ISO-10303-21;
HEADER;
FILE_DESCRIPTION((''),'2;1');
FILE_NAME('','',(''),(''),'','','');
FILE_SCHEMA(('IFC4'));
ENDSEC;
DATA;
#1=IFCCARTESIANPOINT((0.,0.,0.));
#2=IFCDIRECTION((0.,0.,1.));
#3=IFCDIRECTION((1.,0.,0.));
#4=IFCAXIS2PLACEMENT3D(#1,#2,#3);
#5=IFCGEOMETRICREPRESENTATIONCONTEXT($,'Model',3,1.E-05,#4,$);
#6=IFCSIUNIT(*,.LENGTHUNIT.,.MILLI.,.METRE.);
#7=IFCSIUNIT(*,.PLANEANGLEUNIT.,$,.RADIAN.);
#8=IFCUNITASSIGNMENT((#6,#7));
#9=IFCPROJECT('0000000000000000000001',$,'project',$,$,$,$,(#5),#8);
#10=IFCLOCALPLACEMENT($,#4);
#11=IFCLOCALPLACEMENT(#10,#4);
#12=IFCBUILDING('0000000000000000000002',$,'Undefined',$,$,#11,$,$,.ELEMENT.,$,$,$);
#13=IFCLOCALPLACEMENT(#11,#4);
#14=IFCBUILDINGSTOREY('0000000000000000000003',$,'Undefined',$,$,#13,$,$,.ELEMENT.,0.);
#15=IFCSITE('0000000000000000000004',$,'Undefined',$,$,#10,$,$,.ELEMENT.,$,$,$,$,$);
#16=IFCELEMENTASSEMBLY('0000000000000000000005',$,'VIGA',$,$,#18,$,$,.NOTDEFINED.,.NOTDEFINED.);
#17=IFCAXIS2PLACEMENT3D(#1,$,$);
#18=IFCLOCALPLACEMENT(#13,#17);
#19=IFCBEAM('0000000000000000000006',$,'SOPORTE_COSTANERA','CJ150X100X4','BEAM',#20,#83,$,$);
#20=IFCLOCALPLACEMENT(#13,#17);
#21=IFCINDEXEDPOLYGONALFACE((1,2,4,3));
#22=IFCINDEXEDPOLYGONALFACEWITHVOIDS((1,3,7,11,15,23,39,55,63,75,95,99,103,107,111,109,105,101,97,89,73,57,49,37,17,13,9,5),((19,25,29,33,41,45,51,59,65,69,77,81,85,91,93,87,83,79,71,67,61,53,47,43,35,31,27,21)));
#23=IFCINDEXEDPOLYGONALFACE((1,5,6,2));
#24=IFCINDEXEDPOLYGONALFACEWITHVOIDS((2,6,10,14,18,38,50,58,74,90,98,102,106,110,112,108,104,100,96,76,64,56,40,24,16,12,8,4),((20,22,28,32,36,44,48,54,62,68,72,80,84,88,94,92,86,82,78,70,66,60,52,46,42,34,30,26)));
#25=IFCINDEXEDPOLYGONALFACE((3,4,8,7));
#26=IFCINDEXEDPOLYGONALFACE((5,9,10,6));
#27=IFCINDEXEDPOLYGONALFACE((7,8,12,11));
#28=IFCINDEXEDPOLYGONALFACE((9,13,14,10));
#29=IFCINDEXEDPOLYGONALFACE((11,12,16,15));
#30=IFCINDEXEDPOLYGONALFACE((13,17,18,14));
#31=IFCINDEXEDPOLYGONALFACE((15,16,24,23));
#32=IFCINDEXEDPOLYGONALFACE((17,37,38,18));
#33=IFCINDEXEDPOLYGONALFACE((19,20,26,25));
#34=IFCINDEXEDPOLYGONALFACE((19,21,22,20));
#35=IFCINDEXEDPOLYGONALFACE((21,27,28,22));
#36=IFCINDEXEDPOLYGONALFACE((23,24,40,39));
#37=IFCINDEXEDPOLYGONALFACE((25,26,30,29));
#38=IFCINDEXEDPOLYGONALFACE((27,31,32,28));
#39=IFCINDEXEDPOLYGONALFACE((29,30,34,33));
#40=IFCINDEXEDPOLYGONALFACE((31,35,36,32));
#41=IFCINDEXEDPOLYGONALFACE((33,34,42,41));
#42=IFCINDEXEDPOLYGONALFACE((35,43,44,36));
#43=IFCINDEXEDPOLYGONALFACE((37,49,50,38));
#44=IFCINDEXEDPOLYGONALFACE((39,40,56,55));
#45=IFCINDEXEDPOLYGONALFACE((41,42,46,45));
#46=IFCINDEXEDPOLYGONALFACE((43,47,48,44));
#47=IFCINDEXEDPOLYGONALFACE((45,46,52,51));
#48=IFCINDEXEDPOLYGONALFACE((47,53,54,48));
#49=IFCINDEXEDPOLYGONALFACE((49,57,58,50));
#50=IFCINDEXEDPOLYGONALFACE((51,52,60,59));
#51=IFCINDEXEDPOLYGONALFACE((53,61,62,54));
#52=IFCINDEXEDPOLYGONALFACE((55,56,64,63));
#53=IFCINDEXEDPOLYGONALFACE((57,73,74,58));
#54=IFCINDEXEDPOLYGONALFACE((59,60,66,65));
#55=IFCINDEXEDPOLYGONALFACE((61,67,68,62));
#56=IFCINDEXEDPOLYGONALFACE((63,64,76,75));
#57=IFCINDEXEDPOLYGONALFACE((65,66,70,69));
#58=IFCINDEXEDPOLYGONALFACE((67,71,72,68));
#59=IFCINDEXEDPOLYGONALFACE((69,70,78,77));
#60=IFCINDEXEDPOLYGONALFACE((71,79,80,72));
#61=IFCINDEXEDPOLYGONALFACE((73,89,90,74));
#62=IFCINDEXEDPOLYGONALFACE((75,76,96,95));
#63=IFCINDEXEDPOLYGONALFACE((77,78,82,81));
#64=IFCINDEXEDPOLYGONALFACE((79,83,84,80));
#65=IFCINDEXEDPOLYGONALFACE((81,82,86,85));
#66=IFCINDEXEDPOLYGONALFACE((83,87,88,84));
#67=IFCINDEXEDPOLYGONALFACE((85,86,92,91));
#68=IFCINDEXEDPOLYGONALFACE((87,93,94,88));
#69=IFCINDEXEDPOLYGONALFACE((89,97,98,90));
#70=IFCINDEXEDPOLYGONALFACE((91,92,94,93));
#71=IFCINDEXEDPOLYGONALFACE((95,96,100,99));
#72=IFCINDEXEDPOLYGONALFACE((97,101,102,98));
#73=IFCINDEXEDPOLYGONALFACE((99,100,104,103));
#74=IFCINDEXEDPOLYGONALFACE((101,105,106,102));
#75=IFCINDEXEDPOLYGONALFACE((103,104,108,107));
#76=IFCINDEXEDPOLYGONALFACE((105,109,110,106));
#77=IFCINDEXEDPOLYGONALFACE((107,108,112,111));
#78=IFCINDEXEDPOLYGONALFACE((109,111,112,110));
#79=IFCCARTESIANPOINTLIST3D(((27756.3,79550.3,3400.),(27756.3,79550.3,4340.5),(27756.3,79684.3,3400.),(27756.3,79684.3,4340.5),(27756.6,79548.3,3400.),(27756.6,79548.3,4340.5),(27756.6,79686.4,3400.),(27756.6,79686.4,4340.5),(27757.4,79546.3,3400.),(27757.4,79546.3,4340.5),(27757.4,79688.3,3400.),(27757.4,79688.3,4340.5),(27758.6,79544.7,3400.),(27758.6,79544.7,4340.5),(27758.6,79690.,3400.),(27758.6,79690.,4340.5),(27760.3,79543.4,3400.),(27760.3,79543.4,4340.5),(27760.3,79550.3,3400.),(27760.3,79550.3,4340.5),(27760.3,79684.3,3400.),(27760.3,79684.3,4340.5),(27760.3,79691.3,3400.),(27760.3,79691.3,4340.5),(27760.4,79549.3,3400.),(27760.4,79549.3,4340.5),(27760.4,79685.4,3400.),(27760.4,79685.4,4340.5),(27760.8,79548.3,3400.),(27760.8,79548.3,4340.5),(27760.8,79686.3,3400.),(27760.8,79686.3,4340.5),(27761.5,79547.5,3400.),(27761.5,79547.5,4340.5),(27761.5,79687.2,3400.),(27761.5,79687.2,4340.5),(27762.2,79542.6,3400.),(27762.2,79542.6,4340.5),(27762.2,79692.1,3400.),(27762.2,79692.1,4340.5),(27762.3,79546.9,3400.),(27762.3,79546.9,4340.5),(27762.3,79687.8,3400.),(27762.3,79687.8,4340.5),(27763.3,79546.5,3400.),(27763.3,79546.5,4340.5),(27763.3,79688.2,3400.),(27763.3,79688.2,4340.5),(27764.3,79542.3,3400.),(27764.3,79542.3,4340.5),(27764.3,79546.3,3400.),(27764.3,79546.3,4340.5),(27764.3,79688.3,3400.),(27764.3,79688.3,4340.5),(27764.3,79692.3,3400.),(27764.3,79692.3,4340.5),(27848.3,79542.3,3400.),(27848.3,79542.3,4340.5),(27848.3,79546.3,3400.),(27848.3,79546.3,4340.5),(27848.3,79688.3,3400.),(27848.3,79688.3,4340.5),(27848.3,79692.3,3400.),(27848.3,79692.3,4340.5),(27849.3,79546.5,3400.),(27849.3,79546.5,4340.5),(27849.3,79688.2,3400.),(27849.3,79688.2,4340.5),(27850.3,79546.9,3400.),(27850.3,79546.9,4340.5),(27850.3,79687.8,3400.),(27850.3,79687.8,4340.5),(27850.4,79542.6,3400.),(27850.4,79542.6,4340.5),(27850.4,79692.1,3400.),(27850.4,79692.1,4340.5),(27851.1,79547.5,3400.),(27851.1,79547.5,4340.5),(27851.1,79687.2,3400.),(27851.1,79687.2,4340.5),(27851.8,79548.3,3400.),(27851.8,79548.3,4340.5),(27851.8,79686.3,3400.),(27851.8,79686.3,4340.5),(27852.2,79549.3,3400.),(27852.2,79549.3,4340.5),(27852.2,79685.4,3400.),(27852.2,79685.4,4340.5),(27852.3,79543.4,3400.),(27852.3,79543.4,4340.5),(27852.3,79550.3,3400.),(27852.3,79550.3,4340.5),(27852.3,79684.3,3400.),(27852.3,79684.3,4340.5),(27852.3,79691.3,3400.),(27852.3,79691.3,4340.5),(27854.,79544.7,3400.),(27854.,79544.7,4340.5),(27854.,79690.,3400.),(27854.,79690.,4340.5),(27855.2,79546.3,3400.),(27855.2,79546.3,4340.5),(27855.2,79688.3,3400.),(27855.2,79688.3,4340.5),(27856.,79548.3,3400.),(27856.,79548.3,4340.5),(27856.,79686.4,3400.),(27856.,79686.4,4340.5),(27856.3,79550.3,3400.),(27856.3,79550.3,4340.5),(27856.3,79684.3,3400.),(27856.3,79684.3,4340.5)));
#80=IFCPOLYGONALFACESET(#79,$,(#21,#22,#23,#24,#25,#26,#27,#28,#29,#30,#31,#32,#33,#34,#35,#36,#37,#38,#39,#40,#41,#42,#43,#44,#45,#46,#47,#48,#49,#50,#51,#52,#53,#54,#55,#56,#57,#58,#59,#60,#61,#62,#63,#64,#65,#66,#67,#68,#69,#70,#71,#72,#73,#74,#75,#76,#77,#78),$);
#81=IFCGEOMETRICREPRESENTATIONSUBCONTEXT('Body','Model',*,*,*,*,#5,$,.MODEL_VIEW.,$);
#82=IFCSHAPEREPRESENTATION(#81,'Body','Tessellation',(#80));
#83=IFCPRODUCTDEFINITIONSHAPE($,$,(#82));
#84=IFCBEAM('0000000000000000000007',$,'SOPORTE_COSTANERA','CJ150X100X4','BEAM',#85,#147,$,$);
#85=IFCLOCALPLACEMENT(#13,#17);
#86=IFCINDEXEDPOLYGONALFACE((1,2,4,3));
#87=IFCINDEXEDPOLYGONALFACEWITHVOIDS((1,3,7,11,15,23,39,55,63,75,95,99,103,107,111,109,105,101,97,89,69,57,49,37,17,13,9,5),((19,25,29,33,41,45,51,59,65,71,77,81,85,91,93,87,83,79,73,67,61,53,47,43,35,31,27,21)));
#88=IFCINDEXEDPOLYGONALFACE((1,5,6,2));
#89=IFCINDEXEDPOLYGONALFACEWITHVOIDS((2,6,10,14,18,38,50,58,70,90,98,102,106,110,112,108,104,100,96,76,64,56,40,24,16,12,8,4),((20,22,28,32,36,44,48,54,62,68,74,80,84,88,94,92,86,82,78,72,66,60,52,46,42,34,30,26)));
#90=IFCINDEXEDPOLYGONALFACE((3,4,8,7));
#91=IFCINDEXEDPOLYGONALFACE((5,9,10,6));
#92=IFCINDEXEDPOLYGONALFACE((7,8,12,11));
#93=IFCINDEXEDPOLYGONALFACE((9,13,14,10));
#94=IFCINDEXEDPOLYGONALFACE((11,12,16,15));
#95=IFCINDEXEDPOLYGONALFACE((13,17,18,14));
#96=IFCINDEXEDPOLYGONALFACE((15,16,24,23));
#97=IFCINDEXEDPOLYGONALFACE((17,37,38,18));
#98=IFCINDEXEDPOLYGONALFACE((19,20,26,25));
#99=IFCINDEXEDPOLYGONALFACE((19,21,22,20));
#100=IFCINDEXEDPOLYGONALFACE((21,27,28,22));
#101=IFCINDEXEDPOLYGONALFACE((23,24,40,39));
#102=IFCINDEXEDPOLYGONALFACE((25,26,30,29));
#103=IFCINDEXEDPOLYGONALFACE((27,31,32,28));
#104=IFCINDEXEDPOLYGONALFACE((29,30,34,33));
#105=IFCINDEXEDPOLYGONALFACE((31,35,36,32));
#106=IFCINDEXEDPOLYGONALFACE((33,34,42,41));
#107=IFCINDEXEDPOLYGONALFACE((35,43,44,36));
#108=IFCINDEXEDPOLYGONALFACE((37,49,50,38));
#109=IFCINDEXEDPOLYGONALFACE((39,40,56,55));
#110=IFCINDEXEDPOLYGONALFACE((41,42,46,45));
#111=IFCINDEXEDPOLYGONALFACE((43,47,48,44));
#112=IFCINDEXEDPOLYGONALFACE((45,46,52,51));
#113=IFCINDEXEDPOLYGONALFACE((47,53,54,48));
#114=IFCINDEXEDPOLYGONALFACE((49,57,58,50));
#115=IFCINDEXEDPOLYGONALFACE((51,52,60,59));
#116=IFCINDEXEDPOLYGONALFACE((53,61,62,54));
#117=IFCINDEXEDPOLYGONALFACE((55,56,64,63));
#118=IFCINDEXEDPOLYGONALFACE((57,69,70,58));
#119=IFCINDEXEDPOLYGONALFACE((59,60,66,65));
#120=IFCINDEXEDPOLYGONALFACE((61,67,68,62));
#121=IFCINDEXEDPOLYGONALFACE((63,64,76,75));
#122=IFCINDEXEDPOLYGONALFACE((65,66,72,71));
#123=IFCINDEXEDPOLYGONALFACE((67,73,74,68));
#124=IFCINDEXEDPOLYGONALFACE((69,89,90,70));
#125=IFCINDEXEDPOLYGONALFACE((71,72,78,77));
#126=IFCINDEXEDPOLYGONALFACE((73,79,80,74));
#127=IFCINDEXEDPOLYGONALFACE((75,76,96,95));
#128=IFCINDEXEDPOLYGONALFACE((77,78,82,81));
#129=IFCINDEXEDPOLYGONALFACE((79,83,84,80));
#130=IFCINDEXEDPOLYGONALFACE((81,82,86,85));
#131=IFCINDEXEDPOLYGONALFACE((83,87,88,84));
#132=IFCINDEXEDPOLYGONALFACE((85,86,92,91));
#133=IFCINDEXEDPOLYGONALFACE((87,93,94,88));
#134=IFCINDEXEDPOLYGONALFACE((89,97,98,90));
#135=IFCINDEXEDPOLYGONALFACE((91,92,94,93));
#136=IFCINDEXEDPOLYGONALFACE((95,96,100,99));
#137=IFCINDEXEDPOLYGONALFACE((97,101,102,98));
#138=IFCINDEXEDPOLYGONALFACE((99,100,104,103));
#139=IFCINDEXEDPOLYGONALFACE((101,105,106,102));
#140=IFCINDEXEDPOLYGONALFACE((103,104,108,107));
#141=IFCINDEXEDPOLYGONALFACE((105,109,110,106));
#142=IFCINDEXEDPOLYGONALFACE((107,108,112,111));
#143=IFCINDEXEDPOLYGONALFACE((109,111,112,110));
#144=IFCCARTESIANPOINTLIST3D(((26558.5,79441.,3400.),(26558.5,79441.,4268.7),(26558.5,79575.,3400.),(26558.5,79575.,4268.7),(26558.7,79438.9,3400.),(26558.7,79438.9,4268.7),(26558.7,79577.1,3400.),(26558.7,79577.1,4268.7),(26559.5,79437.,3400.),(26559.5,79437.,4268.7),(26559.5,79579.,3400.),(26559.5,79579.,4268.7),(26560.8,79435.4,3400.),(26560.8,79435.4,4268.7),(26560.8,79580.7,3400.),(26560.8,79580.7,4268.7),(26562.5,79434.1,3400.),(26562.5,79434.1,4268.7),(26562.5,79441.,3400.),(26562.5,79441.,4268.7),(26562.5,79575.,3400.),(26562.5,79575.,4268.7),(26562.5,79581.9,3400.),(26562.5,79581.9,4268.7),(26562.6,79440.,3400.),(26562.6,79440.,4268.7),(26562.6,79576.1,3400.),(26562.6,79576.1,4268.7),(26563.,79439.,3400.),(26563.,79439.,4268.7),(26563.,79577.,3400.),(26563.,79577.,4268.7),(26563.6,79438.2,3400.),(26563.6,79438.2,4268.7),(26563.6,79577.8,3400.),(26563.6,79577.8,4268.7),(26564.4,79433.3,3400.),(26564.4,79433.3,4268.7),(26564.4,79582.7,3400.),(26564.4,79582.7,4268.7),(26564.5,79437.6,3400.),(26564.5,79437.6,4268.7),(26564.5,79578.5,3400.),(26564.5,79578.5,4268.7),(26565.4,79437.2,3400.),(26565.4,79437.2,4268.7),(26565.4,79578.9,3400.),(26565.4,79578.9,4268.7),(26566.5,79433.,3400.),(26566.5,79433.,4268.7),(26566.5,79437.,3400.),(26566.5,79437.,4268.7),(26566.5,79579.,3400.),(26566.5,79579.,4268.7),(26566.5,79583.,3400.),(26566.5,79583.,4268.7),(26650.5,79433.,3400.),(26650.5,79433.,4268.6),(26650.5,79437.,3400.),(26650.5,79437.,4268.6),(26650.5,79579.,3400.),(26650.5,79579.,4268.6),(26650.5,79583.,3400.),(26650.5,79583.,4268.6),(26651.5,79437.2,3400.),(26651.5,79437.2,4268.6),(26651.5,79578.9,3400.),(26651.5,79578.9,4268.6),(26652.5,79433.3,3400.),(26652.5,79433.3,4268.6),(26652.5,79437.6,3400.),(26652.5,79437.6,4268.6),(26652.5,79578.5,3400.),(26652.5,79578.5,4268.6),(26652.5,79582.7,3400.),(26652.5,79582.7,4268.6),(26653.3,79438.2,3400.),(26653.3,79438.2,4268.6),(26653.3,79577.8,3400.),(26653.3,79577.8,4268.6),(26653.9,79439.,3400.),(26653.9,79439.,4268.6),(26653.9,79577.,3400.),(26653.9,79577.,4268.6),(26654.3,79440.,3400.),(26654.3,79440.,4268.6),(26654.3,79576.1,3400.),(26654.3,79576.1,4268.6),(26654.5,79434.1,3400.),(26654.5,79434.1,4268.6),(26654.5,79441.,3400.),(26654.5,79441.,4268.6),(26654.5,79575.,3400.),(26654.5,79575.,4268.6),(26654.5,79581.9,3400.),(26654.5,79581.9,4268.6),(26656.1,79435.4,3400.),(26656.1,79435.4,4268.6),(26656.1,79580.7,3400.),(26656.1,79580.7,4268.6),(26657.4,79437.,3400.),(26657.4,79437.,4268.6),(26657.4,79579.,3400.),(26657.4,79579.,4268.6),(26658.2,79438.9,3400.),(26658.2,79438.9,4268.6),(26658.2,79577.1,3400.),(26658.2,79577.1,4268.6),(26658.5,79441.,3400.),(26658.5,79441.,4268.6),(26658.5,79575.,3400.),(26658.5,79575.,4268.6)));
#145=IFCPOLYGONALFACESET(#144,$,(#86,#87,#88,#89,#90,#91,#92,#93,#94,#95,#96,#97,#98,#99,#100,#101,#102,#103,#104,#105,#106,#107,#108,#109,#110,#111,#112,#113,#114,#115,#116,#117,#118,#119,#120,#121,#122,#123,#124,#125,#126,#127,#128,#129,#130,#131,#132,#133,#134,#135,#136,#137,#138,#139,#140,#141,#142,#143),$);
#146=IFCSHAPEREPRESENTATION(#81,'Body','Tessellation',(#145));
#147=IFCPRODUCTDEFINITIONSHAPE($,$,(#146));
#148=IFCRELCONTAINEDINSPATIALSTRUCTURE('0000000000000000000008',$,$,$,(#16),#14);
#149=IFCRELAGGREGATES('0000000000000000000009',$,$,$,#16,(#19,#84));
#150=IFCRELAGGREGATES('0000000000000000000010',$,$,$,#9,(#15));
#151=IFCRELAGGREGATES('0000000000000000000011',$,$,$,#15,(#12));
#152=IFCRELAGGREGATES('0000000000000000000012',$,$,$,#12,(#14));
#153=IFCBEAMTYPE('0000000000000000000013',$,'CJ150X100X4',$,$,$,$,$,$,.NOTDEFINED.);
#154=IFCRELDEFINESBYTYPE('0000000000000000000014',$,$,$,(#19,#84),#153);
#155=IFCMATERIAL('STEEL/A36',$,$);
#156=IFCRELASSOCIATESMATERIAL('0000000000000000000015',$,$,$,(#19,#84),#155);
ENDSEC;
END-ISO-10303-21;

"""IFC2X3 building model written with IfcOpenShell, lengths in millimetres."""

from ifc_helpers import new_model, si_unit, frame, origin_with_axes, origin_2d_with_axis, place, context, subcontext, project, spatial, hollow_rectangle, extrude, material, type_object, element, aggregate, save


model = new_model("IFC2X3")

# Units and contexts
model_context = context("Model", 3, precision=1e-05, world=origin_with_axes())
body_context = subcontext(model_context, "Body", "Model", "MODEL_VIEW")
ifc_project = project(units=[si_unit("LENGTHUNIT", "METRE", prefix="MILLI"), si_unit("PLANEANGLEUNIT", "RADIAN")], contexts=[model_context])

# Site, building, storey
site_placement = place(None, origin_with_axes())
site = spatial("IfcSite", under=ifc_project, at=site_placement, Name="Undefined", CompositionType="ELEMENT")
building_placement = place(site_placement, origin_with_axes())
building = spatial("IfcBuilding", under=site, at=building_placement, Name="Undefined", CompositionType="ELEMENT")
storey_placement = place(building_placement, origin_with_axes())
storey = spatial("IfcBuildingStorey", under=building, at=storey_placement, Name="Undefined", CompositionType="ELEMENT", Elevation=0.0)

# Shared definitions
ifc_material_1 = material(Name="STEEL/A36")
beam_type = type_object("IfcBeamType", Name="CJ150X100X4", PredefinedType="NOTDEFINED")

# Element assembly, beams
assembly_1_placement = place(storey_placement, origin_with_axes())
assembly_1 = element("IfcElementAssembly", 1, at=assembly_1_placement, inside=storey, Name="VIGA", AssemblyPlace="NOTDEFINED", PredefinedType="NOTDEFINED")
beam_1_placement = place(assembly_1_placement, frame((27806.3, 79617.3, 4340.5), z_axis=(0.0, 1.0, 0.0), x_axis=(0.0, 0.0, -1.0)))
beam_1 = element("IfcBeam", 2, at=beam_1_placement, type_object=beam_type, material=ifc_material_1, Name="SOPORTE_COSTANERA", Description="CJ150X100X4", ObjectType="BEAM", context=body_context, shape_type="SweptSolid", body=[
    extrude(hollow_rectangle(XDim=100.0, YDim=150.0, WallThickness=4.0, InnerFilletRadius=4.0, OuterFilletRadius=8.0, at=origin_2d_with_axis()), frame((940.5, 0.0, 0.0), z_axis=(-1.0, 0.0, 0.0), x_axis=(0.0, -1.0, 0.0)), (0.0, 0.0, 1.0), 940.5),
])
beam_2_placement = place(assembly_1_placement, frame((26608.5, 79508.0, 4268.7), z_axis=(0.0, 1.0, 0.0), x_axis=(0.0, 0.0, -1.0)))
beam_2 = element("IfcBeam", 3, at=beam_2_placement, type_object=beam_type, material=ifc_material_1, Name="SOPORTE_COSTANERA", Description="CJ150X100X4", ObjectType="BEAM", context=body_context, shape_type="SweptSolid", body=[
    extrude(hollow_rectangle(XDim=100.0, YDim=150.0, WallThickness=4.0, InnerFilletRadius=4.0, OuterFilletRadius=8.0, at=origin_2d_with_axis()), frame((868.7, 0.0, 0.0), z_axis=(-1.0, 0.0, 0.0), x_axis=(0.0, -1.0, 0.0)), (0.0, 0.0, 1.0), 868.6),
])

aggregate(assembly_1, [beam_1, beam_2])

save(model, "model.ifc")
